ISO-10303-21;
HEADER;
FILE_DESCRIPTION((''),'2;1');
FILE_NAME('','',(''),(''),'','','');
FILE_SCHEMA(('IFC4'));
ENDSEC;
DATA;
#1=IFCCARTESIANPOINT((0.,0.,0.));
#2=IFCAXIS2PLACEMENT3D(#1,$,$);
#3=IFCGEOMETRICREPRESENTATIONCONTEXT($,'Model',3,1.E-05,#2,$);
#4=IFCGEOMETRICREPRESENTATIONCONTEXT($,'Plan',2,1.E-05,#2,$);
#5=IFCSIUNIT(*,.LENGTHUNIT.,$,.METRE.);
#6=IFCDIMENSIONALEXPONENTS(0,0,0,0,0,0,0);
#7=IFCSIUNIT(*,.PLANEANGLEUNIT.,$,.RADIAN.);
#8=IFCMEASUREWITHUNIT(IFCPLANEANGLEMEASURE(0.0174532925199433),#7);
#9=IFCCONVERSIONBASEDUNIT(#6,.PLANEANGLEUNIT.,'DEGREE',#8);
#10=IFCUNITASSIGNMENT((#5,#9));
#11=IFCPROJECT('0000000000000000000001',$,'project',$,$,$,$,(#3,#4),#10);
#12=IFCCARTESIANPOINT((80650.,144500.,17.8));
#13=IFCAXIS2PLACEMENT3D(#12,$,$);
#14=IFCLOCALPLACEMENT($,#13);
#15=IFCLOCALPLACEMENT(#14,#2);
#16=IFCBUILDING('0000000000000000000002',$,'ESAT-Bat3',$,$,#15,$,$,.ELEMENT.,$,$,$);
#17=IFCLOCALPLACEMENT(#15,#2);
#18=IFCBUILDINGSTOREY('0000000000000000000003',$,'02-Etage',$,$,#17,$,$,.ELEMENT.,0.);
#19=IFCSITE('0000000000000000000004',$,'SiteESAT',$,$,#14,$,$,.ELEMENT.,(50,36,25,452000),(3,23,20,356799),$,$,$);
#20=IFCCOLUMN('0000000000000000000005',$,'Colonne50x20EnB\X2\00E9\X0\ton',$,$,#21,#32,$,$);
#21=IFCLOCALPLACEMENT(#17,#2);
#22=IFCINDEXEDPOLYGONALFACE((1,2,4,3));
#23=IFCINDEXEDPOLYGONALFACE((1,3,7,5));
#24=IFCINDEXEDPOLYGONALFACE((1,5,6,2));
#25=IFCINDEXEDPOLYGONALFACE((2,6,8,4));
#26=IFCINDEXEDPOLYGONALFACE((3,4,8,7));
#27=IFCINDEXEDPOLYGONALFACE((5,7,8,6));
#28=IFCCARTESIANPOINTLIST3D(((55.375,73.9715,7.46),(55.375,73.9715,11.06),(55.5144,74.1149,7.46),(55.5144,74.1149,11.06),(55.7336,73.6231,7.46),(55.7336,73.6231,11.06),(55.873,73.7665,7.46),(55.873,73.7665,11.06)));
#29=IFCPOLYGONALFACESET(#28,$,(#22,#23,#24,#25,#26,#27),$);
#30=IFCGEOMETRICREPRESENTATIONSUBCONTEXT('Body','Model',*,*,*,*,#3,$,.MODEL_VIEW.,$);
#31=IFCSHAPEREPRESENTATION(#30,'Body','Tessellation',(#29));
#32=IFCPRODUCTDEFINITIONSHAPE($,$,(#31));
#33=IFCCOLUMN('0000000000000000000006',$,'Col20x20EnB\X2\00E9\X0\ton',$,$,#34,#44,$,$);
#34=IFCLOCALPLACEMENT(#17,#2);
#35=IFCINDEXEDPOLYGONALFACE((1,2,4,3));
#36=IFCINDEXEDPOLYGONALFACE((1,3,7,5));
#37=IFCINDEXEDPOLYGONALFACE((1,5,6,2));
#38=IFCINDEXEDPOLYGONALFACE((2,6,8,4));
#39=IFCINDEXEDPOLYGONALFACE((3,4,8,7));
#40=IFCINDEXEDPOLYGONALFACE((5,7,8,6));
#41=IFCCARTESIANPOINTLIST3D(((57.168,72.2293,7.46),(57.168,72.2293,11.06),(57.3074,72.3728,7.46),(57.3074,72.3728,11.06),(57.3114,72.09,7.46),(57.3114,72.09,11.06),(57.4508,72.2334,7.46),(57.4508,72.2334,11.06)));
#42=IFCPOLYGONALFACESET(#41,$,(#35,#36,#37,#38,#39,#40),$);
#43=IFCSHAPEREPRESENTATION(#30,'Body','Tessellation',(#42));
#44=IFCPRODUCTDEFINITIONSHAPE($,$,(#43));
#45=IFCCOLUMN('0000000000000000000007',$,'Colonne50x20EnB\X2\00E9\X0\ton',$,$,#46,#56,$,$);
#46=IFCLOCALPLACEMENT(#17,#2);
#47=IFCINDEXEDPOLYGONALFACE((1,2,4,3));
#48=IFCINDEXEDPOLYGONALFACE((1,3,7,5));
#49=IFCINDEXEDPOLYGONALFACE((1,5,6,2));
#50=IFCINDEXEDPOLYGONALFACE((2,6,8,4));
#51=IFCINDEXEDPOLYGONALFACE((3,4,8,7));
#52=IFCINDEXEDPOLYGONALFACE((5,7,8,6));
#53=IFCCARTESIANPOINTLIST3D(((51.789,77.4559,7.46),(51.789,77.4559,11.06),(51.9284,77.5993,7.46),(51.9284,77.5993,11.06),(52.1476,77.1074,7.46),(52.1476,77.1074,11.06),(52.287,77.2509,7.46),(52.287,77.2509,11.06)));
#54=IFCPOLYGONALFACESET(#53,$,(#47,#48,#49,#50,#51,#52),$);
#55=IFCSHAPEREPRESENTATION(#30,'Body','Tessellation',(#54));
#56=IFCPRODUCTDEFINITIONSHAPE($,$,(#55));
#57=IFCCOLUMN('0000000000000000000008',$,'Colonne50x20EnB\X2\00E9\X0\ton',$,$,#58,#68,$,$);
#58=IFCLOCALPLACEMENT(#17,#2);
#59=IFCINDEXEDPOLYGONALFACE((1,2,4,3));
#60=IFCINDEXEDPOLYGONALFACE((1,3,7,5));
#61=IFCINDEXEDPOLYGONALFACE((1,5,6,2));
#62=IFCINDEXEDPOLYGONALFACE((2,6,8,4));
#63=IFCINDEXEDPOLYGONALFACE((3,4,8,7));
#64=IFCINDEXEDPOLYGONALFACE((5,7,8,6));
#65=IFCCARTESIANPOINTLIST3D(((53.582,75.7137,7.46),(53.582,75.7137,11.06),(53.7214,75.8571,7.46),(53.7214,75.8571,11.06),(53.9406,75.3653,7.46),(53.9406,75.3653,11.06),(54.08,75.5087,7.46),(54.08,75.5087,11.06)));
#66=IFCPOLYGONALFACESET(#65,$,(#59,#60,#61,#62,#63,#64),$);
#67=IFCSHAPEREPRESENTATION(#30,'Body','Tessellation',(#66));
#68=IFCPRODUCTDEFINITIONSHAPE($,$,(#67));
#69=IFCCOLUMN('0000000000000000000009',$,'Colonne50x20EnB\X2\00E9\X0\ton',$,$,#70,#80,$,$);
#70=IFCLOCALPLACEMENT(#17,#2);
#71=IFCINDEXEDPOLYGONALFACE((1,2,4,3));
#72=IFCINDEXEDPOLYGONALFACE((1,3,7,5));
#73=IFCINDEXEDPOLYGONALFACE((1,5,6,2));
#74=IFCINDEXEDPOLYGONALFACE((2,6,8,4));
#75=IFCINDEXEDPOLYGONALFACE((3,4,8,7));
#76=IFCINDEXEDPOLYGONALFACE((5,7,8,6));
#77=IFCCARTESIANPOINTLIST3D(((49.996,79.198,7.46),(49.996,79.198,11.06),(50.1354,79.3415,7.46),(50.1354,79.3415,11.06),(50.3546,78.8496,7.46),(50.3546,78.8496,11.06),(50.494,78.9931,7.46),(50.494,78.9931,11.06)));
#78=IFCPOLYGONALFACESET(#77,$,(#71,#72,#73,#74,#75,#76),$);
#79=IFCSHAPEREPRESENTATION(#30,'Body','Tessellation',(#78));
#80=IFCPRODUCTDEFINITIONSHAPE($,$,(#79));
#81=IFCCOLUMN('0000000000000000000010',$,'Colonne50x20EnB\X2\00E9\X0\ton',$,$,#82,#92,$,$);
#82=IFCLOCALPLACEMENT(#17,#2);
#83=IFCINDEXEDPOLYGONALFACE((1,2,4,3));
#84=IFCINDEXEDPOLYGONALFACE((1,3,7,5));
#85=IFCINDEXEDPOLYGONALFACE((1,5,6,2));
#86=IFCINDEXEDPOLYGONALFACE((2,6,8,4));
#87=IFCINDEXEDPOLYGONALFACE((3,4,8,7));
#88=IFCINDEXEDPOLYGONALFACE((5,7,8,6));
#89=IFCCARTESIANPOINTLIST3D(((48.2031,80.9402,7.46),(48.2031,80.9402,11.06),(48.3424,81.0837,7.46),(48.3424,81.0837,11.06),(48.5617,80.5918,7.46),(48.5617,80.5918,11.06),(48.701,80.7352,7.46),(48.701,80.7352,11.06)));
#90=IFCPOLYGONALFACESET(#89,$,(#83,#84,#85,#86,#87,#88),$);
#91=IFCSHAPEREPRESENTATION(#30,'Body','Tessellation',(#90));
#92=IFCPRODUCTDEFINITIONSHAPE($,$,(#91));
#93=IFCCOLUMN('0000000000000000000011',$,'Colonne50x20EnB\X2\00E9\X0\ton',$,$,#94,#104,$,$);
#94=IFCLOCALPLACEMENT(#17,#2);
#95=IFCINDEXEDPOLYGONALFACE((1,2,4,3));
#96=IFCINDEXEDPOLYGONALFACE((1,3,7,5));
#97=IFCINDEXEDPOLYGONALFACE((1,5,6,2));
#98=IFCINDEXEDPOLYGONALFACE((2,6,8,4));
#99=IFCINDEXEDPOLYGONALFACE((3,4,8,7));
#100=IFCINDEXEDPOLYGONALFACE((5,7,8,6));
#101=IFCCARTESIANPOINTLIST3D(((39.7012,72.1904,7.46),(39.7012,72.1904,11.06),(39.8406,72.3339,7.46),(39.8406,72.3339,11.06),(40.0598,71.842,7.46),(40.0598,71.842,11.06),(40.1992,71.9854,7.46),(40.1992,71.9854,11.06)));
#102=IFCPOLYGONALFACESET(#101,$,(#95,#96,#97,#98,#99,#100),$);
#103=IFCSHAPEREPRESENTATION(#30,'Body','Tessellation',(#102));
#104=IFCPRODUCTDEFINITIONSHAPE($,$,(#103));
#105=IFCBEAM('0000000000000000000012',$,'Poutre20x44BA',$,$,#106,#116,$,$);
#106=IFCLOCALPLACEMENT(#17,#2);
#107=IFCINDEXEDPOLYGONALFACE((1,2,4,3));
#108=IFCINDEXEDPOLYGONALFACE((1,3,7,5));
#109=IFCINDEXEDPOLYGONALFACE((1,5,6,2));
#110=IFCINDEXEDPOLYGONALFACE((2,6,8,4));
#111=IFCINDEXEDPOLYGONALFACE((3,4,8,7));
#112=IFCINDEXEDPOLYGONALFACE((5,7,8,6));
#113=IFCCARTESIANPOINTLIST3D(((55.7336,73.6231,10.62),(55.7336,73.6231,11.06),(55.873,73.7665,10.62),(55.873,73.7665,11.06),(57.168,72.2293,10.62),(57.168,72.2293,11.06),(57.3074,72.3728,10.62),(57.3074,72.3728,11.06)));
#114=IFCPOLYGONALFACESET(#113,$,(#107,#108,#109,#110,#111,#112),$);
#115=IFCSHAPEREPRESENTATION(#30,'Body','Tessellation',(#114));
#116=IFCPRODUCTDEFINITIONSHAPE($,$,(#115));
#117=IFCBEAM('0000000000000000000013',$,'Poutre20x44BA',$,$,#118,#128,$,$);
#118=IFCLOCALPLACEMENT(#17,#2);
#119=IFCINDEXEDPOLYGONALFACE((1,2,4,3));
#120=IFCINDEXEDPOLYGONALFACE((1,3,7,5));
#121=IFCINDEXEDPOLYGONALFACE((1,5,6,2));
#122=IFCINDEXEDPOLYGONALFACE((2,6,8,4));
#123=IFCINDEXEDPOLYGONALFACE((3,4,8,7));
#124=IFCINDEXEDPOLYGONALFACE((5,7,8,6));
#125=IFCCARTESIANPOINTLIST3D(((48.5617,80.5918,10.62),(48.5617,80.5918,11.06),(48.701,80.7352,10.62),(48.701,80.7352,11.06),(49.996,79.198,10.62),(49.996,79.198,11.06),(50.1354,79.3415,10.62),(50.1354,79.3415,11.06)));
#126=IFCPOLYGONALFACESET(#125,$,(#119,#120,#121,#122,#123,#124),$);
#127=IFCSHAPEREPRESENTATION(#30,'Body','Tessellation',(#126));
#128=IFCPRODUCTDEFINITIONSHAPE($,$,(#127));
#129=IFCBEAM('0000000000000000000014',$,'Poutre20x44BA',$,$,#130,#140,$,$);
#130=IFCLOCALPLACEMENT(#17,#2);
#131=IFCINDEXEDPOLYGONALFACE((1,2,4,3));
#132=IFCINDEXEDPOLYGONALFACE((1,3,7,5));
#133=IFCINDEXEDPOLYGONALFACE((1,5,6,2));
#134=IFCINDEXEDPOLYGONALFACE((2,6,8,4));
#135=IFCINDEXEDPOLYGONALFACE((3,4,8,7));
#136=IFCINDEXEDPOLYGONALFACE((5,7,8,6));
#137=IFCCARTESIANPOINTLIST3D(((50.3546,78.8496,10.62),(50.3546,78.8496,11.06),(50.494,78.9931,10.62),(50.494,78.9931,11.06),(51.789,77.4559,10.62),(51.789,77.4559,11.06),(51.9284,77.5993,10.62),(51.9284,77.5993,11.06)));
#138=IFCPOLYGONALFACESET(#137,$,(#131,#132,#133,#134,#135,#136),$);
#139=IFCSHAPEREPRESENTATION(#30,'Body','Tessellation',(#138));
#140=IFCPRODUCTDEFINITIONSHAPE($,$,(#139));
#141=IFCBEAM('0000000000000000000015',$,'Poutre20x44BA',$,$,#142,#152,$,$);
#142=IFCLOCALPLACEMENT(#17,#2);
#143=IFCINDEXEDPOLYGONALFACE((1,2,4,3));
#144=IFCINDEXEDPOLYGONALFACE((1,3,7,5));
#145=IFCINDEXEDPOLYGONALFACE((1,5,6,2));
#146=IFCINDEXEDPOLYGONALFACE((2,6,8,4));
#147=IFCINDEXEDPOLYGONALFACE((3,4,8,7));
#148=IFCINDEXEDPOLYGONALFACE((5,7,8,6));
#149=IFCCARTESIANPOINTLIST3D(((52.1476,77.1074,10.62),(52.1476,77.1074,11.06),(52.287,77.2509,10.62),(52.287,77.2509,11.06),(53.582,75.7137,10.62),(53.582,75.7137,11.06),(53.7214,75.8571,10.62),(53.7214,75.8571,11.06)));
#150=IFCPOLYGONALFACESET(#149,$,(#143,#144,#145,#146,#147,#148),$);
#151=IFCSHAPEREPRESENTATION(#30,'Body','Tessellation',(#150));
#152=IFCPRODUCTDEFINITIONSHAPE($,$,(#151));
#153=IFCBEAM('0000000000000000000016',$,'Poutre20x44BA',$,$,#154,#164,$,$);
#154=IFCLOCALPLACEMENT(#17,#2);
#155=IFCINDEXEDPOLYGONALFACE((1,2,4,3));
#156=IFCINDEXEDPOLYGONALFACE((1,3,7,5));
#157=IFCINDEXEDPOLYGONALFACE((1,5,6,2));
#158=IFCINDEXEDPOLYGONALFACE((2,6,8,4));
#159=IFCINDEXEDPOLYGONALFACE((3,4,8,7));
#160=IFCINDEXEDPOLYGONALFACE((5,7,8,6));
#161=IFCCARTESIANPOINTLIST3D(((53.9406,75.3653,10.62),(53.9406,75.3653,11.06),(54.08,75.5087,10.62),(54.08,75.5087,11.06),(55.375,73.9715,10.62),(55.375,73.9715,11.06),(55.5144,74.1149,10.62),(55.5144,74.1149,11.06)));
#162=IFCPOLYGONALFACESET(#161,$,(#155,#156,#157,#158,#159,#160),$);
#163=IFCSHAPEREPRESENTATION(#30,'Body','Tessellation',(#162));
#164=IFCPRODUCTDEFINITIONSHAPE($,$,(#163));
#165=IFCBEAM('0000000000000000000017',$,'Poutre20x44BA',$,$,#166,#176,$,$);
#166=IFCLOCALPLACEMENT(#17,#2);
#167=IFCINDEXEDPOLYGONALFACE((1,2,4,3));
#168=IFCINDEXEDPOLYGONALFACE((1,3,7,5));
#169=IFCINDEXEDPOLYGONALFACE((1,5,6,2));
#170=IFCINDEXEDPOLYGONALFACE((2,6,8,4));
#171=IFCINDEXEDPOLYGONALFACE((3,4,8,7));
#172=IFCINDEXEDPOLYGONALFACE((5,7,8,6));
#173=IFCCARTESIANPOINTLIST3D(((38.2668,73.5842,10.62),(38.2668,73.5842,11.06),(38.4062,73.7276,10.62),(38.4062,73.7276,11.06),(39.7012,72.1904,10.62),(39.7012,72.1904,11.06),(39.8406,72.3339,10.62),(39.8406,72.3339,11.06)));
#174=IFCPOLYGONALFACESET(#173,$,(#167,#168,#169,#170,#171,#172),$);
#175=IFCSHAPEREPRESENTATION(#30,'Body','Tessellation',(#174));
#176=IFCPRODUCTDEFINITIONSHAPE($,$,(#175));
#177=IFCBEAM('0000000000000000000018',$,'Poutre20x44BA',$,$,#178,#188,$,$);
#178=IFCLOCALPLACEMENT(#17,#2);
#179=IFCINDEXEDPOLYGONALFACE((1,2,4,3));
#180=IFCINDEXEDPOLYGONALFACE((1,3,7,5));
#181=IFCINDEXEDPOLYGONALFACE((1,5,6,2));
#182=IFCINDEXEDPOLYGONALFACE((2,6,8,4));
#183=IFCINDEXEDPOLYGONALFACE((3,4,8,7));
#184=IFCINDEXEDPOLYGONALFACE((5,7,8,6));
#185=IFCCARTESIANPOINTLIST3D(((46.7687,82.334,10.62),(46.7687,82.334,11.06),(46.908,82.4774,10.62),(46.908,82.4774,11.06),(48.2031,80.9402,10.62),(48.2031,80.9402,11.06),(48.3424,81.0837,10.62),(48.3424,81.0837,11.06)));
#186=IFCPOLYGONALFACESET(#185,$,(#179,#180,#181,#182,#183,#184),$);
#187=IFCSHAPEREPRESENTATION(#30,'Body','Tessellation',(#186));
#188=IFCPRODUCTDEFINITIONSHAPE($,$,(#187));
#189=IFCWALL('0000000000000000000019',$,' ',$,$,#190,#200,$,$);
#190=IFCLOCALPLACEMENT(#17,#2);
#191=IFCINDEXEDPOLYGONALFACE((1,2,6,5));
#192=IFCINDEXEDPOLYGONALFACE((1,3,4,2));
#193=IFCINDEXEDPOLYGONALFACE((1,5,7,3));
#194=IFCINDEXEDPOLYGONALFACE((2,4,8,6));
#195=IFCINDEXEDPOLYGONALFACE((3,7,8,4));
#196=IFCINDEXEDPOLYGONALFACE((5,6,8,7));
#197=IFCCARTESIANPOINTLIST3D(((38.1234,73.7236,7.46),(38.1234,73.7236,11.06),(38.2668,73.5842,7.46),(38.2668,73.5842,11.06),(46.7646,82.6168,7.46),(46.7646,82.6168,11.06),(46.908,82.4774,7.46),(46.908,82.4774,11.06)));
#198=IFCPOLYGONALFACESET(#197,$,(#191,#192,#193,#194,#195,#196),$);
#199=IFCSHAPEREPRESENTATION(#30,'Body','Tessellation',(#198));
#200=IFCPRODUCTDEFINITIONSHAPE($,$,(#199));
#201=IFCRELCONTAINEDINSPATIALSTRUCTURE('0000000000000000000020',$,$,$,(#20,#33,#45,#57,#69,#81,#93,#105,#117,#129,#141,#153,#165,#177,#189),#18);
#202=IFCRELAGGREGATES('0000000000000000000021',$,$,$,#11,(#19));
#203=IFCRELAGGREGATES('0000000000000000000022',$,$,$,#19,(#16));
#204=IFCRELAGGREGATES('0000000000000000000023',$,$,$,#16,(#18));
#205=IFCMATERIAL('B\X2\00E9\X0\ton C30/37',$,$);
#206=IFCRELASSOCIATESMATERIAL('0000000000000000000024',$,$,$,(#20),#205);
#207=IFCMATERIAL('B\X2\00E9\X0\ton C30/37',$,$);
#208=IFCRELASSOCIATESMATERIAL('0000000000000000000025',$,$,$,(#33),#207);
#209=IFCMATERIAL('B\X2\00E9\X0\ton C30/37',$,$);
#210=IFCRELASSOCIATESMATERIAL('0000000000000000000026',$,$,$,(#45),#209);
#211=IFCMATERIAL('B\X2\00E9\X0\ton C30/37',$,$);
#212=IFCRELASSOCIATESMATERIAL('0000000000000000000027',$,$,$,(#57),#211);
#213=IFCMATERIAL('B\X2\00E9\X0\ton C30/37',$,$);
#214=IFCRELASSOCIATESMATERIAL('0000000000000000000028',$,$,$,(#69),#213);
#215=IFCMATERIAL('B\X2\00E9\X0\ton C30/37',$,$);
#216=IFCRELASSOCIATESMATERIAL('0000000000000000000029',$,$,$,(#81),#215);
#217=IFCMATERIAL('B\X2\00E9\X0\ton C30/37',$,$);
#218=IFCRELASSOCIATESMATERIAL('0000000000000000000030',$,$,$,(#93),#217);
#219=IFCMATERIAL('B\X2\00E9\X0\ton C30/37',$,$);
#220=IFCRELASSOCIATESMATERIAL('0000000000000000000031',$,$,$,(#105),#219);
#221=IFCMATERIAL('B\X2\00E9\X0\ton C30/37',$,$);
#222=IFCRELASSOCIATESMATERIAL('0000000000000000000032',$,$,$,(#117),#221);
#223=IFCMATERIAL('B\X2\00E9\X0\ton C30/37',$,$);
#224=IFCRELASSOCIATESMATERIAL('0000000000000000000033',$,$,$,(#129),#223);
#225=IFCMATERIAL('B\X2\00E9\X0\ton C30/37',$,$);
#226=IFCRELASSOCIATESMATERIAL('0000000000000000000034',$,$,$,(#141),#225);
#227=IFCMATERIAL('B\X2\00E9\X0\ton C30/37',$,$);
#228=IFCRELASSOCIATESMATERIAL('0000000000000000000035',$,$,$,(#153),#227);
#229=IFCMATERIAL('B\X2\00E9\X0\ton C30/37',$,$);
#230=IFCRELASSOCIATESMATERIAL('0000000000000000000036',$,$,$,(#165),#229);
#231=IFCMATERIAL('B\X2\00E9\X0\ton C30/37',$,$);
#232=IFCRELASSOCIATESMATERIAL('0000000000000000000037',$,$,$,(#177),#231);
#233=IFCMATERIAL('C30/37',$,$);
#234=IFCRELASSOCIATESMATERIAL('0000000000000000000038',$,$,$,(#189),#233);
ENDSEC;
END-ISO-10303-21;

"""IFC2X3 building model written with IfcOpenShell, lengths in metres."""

from ifc_helpers import new_model, entity, si_unit, converted_unit, frame, frame_2d, origin, origin_with_axes, place, context, subcontext, project, spatial, rectangle, extrude, material, element, save


model = new_model("IFC2X3")

# Units and contexts
model_context = context("Model", 3, precision=1e-05, world=origin())
plan_context = context("Plan", 2, precision=1e-05, world=origin())
body_context = subcontext(model_context, "Body", "Model", "MODEL_VIEW")
ifc_project = project(units=[si_unit("LENGTHUNIT", "METRE"), converted_unit("PLANEANGLEUNIT", "DEGREE", entity("IfcPlaneAngleMeasure", 0.0174532925199433), si_unit("PLANEANGLEUNIT", "RADIAN"), dimensions=[0, 0, 0, 0, 0, 0, 0])], contexts=[model_context, plan_context])

# Site, building, storey
site_placement = place(None, frame((80650.0, 144500.0, 17.8)))
site = spatial("IfcSite", under=ifc_project, at=site_placement, Name="SiteESAT", CompositionType="ELEMENT", RefLatitude=(50, 36, 25, 452000), RefLongitude=(3, 23, 20, 356799))
building_placement = place(site_placement, origin())
building = spatial("IfcBuilding", under=site, at=building_placement, Name="ESAT-Bat3", CompositionType="ELEMENT")
storey_placement = place(building_placement, origin())
storey = spatial("IfcBuildingStorey", under=building, at=storey_placement, Name="02-Etage", CompositionType="ELEMENT", Elevation=0.0)

# Columns
ifc_material_1 = material(Name="Béton C30/37")
column_1_placement = place(storey_placement, frame((55.873, 73.7665, 7.46)))
element("IfcColumn", 1, at=column_1_placement, inside=storey, material=ifc_material_1, Name="Colonne50x20EnBéton", context=body_context, shape_type="SweptSolid", body=[
    extrude(rectangle(XDim=0.5, YDim=0.2, at=frame_2d((-0.249, 0.1025), x_axis=(-0.717196, 0.696872))), origin_with_axes(), (0.0, 0.0, 1.0), 3.6),
])
ifc_material_2 = material(Name="Béton C30/37")
column_2_placement = place(storey_placement, frame((57.3114, 72.09, 7.46)))
element("IfcColumn", 2, at=column_2_placement, inside=storey, material=ifc_material_2, Name="Col20x20EnBéton", context=body_context, shape_type="SweptSolid", body=[
    extrude(rectangle(XDim=0.2, YDim=0.2, at=frame_2d((-0.002, 0.1414), x_axis=(0.696872, 0.717196))), origin_with_axes(), (0.0, 0.0, 1.0), 3.6),
])
ifc_material_3 = material(Name="Béton C30/37")
column_3_placement = place(storey_placement, frame((52.287, 77.2509, 7.46)))
element("IfcColumn", 3, at=column_3_placement, inside=storey, material=ifc_material_3, Name="Colonne50x20EnBéton", context=body_context, shape_type="SweptSolid", body=[
    extrude(rectangle(XDim=0.5, YDim=0.2, at=frame_2d((-0.249, 0.1025), x_axis=(-0.717196, 0.696872))), origin_with_axes(), (0.0, 0.0, 1.0), 3.6),
])
ifc_material_4 = material(Name="Béton C30/37")
column_4_placement = place(storey_placement, frame((54.08, 75.5087, 7.46)))
element("IfcColumn", 4, at=column_4_placement, inside=storey, material=ifc_material_4, Name="Colonne50x20EnBéton", context=body_context, shape_type="SweptSolid", body=[
    extrude(rectangle(XDim=0.5, YDim=0.2, at=frame_2d((-0.249, 0.1025), x_axis=(-0.717196, 0.696872))), origin_with_axes(), (0.0, 0.0, 1.0), 3.6),
])
ifc_material_5 = material(Name="Béton C30/37")
column_5_placement = place(storey_placement, frame((50.494, 78.9931, 7.46)))
element("IfcColumn", 5, at=column_5_placement, inside=storey, material=ifc_material_5, Name="Colonne50x20EnBéton", context=body_context, shape_type="SweptSolid", body=[
    extrude(rectangle(XDim=0.5, YDim=0.2, at=frame_2d((-0.249, 0.1025), x_axis=(-0.717196, 0.696872))), origin_with_axes(), (0.0, 0.0, 1.0), 3.6),
])
ifc_material_6 = material(Name="Béton C30/37")
column_6_placement = place(storey_placement, frame((48.701, 80.7352, 7.46)))
element("IfcColumn", 6, at=column_6_placement, inside=storey, material=ifc_material_6, Name="Colonne50x20EnBéton", context=body_context, shape_type="SweptSolid", body=[
    extrude(rectangle(XDim=0.5, YDim=0.2, at=frame_2d((-0.249, 0.1025), x_axis=(-0.717196, 0.696872))), origin_with_axes(), (0.0, 0.0, 1.0), 3.6),
])
ifc_material_7 = material(Name="Béton C30/37")
column_7_placement = place(storey_placement, frame((40.1992, 71.9854, 7.46)))
element("IfcColumn", 7, at=column_7_placement, inside=storey, material=ifc_material_7, Name="Colonne50x20EnBéton", context=body_context, shape_type="SweptSolid", body=[
    extrude(rectangle(XDim=0.5, YDim=0.2, at=frame_2d((-0.249, 0.1025), x_axis=(-0.717196, 0.696872))), origin_with_axes(), (0.0, 0.0, 1.0), 3.6),
])

# Beams
ifc_material_8 = material(Name="Béton C30/37")
beam_1_placement = place(storey_placement, frame((57.3074, 72.3728, 10.62), z_axis=(0.0, 0.0, 1.0), x_axis=(-0.717196, 0.696872, 0.0)))
element("IfcBeam", 8, at=beam_1_placement, inside=storey, material=ifc_material_8, Name="Poutre20x44BA", context=body_context, shape_type="SweptSolid", body=[
    extrude(rectangle(XDim=0.2, YDim=0.44, at=frame_2d((0.1, 0.22), x_axis=(1.0, 0.0))), frame((0.0, 0.0, 0.0), z_axis=(1.0, 0.0, 0.0), x_axis=(0.0, 1.0, 0.0)), (0.0, 0.0, 1.0), 2.0),
])
ifc_material_9 = material(Name="Béton C30/37")
beam_2_placement = place(storey_placement, frame((50.1354, 79.3415, 10.62), z_axis=(0.0, 0.0, 1.0), x_axis=(-0.717196, 0.696872, 0.0)))
element("IfcBeam", 9, at=beam_2_placement, inside=storey, material=ifc_material_9, Name="Poutre20x44BA", context=body_context, shape_type="SweptSolid", body=[
    extrude(rectangle(XDim=0.2, YDim=0.44, at=frame_2d((0.1, 0.22), x_axis=(1.0, 0.0))), frame((0.0, 0.0, 0.0), z_axis=(1.0, 0.0, 0.0), x_axis=(0.0, 1.0, 0.0)), (0.0, 0.0, 1.0), 2.0),
])
ifc_material_10 = material(Name="Béton C30/37")
beam_3_placement = place(storey_placement, frame((51.9284, 77.5993, 10.62), z_axis=(0.0, 0.0, 1.0), x_axis=(-0.717196, 0.696872, 0.0)))
element("IfcBeam", 10, at=beam_3_placement, inside=storey, material=ifc_material_10, Name="Poutre20x44BA", context=body_context, shape_type="SweptSolid", body=[
    extrude(rectangle(XDim=0.2, YDim=0.44, at=frame_2d((0.1, 0.22), x_axis=(1.0, 0.0))), frame((0.0, 0.0, 0.0), z_axis=(1.0, 0.0, 0.0), x_axis=(0.0, 1.0, 0.0)), (0.0, 0.0, 1.0), 2.0),
])
ifc_material_11 = material(Name="Béton C30/37")
beam_4_placement = place(storey_placement, frame((53.7214, 75.8571, 10.62), z_axis=(0.0, 0.0, 1.0), x_axis=(-0.717196, 0.696872, 0.0)))
element("IfcBeam", 11, at=beam_4_placement, inside=storey, material=ifc_material_11, Name="Poutre20x44BA", context=body_context, shape_type="SweptSolid", body=[
    extrude(rectangle(XDim=0.2, YDim=0.44, at=frame_2d((0.1, 0.22), x_axis=(1.0, 0.0))), frame((0.0, 0.0, 0.0), z_axis=(1.0, 0.0, 0.0), x_axis=(0.0, 1.0, 0.0)), (0.0, 0.0, 1.0), 2.0),
])
ifc_material_12 = material(Name="Béton C30/37")
beam_5_placement = place(storey_placement, frame((55.5144, 74.1149, 10.62), z_axis=(0.0, 0.0, 1.0), x_axis=(-0.717196, 0.696872, 0.0)))
element("IfcBeam", 12, at=beam_5_placement, inside=storey, material=ifc_material_12, Name="Poutre20x44BA", context=body_context, shape_type="SweptSolid", body=[
    extrude(rectangle(XDim=0.2, YDim=0.44, at=frame_2d((0.1, 0.22), x_axis=(1.0, 0.0))), frame((0.0, 0.0, 0.0), z_axis=(1.0, 0.0, 0.0), x_axis=(0.0, 1.0, 0.0)), (0.0, 0.0, 1.0), 2.0),
])
ifc_material_13 = material(Name="Béton C30/37")
beam_6_placement = place(storey_placement, frame((39.8406, 72.3339, 10.62), z_axis=(0.0, 0.0, 1.0), x_axis=(-0.717196, 0.696872, 0.0)))
element("IfcBeam", 13, at=beam_6_placement, inside=storey, material=ifc_material_13, Name="Poutre20x44BA", context=body_context, shape_type="SweptSolid", body=[
    extrude(rectangle(XDim=0.2, YDim=0.44, at=frame_2d((0.1, 0.22), x_axis=(1.0, 0.0))), frame((0.0, 0.0, 0.0), z_axis=(1.0, 0.0, 0.0), x_axis=(0.0, 1.0, 0.0)), (0.0, 0.0, 1.0), 2.0),
])
ifc_material_14 = material(Name="Béton C30/37")
beam_7_placement = place(storey_placement, frame((48.3424, 81.0837, 10.62), z_axis=(0.0, 0.0, 1.0), x_axis=(-0.717196, 0.696872, 0.0)))
element("IfcBeam", 14, at=beam_7_placement, inside=storey, material=ifc_material_14, Name="Poutre20x44BA", context=body_context, shape_type="SweptSolid", body=[
    extrude(rectangle(XDim=0.2, YDim=0.44, at=frame_2d((0.1, 0.22), x_axis=(1.0, 0.0))), frame((0.0, 0.0, 0.0), z_axis=(1.0, 0.0, 0.0), x_axis=(0.0, 1.0, 0.0)), (0.0, 0.0, 1.0), 2.0),
])

# Wall
ifc_material_15 = material(Name="C30/37")
wall_1_placement = place(storey_placement, frame((46.7646, 82.6168, 7.46), z_axis=(0.0, 0.0, 1.0), x_axis=(-0.696872, -0.717196, 0.0)))
element("IfcWall", 15, at=wall_1_placement, inside=storey, material=ifc_material_15, Name=" ", context=body_context, shape_type="SweptSolid", body=[
    extrude(rectangle(XDim=12.4, YDim=0.2, at=frame_2d((6.2, 0.1), x_axis=(1.0, 0.0))), origin_with_axes(), (0.0, 0.0, 1.0), 3.6),
])

save(model, "model.ifc")
